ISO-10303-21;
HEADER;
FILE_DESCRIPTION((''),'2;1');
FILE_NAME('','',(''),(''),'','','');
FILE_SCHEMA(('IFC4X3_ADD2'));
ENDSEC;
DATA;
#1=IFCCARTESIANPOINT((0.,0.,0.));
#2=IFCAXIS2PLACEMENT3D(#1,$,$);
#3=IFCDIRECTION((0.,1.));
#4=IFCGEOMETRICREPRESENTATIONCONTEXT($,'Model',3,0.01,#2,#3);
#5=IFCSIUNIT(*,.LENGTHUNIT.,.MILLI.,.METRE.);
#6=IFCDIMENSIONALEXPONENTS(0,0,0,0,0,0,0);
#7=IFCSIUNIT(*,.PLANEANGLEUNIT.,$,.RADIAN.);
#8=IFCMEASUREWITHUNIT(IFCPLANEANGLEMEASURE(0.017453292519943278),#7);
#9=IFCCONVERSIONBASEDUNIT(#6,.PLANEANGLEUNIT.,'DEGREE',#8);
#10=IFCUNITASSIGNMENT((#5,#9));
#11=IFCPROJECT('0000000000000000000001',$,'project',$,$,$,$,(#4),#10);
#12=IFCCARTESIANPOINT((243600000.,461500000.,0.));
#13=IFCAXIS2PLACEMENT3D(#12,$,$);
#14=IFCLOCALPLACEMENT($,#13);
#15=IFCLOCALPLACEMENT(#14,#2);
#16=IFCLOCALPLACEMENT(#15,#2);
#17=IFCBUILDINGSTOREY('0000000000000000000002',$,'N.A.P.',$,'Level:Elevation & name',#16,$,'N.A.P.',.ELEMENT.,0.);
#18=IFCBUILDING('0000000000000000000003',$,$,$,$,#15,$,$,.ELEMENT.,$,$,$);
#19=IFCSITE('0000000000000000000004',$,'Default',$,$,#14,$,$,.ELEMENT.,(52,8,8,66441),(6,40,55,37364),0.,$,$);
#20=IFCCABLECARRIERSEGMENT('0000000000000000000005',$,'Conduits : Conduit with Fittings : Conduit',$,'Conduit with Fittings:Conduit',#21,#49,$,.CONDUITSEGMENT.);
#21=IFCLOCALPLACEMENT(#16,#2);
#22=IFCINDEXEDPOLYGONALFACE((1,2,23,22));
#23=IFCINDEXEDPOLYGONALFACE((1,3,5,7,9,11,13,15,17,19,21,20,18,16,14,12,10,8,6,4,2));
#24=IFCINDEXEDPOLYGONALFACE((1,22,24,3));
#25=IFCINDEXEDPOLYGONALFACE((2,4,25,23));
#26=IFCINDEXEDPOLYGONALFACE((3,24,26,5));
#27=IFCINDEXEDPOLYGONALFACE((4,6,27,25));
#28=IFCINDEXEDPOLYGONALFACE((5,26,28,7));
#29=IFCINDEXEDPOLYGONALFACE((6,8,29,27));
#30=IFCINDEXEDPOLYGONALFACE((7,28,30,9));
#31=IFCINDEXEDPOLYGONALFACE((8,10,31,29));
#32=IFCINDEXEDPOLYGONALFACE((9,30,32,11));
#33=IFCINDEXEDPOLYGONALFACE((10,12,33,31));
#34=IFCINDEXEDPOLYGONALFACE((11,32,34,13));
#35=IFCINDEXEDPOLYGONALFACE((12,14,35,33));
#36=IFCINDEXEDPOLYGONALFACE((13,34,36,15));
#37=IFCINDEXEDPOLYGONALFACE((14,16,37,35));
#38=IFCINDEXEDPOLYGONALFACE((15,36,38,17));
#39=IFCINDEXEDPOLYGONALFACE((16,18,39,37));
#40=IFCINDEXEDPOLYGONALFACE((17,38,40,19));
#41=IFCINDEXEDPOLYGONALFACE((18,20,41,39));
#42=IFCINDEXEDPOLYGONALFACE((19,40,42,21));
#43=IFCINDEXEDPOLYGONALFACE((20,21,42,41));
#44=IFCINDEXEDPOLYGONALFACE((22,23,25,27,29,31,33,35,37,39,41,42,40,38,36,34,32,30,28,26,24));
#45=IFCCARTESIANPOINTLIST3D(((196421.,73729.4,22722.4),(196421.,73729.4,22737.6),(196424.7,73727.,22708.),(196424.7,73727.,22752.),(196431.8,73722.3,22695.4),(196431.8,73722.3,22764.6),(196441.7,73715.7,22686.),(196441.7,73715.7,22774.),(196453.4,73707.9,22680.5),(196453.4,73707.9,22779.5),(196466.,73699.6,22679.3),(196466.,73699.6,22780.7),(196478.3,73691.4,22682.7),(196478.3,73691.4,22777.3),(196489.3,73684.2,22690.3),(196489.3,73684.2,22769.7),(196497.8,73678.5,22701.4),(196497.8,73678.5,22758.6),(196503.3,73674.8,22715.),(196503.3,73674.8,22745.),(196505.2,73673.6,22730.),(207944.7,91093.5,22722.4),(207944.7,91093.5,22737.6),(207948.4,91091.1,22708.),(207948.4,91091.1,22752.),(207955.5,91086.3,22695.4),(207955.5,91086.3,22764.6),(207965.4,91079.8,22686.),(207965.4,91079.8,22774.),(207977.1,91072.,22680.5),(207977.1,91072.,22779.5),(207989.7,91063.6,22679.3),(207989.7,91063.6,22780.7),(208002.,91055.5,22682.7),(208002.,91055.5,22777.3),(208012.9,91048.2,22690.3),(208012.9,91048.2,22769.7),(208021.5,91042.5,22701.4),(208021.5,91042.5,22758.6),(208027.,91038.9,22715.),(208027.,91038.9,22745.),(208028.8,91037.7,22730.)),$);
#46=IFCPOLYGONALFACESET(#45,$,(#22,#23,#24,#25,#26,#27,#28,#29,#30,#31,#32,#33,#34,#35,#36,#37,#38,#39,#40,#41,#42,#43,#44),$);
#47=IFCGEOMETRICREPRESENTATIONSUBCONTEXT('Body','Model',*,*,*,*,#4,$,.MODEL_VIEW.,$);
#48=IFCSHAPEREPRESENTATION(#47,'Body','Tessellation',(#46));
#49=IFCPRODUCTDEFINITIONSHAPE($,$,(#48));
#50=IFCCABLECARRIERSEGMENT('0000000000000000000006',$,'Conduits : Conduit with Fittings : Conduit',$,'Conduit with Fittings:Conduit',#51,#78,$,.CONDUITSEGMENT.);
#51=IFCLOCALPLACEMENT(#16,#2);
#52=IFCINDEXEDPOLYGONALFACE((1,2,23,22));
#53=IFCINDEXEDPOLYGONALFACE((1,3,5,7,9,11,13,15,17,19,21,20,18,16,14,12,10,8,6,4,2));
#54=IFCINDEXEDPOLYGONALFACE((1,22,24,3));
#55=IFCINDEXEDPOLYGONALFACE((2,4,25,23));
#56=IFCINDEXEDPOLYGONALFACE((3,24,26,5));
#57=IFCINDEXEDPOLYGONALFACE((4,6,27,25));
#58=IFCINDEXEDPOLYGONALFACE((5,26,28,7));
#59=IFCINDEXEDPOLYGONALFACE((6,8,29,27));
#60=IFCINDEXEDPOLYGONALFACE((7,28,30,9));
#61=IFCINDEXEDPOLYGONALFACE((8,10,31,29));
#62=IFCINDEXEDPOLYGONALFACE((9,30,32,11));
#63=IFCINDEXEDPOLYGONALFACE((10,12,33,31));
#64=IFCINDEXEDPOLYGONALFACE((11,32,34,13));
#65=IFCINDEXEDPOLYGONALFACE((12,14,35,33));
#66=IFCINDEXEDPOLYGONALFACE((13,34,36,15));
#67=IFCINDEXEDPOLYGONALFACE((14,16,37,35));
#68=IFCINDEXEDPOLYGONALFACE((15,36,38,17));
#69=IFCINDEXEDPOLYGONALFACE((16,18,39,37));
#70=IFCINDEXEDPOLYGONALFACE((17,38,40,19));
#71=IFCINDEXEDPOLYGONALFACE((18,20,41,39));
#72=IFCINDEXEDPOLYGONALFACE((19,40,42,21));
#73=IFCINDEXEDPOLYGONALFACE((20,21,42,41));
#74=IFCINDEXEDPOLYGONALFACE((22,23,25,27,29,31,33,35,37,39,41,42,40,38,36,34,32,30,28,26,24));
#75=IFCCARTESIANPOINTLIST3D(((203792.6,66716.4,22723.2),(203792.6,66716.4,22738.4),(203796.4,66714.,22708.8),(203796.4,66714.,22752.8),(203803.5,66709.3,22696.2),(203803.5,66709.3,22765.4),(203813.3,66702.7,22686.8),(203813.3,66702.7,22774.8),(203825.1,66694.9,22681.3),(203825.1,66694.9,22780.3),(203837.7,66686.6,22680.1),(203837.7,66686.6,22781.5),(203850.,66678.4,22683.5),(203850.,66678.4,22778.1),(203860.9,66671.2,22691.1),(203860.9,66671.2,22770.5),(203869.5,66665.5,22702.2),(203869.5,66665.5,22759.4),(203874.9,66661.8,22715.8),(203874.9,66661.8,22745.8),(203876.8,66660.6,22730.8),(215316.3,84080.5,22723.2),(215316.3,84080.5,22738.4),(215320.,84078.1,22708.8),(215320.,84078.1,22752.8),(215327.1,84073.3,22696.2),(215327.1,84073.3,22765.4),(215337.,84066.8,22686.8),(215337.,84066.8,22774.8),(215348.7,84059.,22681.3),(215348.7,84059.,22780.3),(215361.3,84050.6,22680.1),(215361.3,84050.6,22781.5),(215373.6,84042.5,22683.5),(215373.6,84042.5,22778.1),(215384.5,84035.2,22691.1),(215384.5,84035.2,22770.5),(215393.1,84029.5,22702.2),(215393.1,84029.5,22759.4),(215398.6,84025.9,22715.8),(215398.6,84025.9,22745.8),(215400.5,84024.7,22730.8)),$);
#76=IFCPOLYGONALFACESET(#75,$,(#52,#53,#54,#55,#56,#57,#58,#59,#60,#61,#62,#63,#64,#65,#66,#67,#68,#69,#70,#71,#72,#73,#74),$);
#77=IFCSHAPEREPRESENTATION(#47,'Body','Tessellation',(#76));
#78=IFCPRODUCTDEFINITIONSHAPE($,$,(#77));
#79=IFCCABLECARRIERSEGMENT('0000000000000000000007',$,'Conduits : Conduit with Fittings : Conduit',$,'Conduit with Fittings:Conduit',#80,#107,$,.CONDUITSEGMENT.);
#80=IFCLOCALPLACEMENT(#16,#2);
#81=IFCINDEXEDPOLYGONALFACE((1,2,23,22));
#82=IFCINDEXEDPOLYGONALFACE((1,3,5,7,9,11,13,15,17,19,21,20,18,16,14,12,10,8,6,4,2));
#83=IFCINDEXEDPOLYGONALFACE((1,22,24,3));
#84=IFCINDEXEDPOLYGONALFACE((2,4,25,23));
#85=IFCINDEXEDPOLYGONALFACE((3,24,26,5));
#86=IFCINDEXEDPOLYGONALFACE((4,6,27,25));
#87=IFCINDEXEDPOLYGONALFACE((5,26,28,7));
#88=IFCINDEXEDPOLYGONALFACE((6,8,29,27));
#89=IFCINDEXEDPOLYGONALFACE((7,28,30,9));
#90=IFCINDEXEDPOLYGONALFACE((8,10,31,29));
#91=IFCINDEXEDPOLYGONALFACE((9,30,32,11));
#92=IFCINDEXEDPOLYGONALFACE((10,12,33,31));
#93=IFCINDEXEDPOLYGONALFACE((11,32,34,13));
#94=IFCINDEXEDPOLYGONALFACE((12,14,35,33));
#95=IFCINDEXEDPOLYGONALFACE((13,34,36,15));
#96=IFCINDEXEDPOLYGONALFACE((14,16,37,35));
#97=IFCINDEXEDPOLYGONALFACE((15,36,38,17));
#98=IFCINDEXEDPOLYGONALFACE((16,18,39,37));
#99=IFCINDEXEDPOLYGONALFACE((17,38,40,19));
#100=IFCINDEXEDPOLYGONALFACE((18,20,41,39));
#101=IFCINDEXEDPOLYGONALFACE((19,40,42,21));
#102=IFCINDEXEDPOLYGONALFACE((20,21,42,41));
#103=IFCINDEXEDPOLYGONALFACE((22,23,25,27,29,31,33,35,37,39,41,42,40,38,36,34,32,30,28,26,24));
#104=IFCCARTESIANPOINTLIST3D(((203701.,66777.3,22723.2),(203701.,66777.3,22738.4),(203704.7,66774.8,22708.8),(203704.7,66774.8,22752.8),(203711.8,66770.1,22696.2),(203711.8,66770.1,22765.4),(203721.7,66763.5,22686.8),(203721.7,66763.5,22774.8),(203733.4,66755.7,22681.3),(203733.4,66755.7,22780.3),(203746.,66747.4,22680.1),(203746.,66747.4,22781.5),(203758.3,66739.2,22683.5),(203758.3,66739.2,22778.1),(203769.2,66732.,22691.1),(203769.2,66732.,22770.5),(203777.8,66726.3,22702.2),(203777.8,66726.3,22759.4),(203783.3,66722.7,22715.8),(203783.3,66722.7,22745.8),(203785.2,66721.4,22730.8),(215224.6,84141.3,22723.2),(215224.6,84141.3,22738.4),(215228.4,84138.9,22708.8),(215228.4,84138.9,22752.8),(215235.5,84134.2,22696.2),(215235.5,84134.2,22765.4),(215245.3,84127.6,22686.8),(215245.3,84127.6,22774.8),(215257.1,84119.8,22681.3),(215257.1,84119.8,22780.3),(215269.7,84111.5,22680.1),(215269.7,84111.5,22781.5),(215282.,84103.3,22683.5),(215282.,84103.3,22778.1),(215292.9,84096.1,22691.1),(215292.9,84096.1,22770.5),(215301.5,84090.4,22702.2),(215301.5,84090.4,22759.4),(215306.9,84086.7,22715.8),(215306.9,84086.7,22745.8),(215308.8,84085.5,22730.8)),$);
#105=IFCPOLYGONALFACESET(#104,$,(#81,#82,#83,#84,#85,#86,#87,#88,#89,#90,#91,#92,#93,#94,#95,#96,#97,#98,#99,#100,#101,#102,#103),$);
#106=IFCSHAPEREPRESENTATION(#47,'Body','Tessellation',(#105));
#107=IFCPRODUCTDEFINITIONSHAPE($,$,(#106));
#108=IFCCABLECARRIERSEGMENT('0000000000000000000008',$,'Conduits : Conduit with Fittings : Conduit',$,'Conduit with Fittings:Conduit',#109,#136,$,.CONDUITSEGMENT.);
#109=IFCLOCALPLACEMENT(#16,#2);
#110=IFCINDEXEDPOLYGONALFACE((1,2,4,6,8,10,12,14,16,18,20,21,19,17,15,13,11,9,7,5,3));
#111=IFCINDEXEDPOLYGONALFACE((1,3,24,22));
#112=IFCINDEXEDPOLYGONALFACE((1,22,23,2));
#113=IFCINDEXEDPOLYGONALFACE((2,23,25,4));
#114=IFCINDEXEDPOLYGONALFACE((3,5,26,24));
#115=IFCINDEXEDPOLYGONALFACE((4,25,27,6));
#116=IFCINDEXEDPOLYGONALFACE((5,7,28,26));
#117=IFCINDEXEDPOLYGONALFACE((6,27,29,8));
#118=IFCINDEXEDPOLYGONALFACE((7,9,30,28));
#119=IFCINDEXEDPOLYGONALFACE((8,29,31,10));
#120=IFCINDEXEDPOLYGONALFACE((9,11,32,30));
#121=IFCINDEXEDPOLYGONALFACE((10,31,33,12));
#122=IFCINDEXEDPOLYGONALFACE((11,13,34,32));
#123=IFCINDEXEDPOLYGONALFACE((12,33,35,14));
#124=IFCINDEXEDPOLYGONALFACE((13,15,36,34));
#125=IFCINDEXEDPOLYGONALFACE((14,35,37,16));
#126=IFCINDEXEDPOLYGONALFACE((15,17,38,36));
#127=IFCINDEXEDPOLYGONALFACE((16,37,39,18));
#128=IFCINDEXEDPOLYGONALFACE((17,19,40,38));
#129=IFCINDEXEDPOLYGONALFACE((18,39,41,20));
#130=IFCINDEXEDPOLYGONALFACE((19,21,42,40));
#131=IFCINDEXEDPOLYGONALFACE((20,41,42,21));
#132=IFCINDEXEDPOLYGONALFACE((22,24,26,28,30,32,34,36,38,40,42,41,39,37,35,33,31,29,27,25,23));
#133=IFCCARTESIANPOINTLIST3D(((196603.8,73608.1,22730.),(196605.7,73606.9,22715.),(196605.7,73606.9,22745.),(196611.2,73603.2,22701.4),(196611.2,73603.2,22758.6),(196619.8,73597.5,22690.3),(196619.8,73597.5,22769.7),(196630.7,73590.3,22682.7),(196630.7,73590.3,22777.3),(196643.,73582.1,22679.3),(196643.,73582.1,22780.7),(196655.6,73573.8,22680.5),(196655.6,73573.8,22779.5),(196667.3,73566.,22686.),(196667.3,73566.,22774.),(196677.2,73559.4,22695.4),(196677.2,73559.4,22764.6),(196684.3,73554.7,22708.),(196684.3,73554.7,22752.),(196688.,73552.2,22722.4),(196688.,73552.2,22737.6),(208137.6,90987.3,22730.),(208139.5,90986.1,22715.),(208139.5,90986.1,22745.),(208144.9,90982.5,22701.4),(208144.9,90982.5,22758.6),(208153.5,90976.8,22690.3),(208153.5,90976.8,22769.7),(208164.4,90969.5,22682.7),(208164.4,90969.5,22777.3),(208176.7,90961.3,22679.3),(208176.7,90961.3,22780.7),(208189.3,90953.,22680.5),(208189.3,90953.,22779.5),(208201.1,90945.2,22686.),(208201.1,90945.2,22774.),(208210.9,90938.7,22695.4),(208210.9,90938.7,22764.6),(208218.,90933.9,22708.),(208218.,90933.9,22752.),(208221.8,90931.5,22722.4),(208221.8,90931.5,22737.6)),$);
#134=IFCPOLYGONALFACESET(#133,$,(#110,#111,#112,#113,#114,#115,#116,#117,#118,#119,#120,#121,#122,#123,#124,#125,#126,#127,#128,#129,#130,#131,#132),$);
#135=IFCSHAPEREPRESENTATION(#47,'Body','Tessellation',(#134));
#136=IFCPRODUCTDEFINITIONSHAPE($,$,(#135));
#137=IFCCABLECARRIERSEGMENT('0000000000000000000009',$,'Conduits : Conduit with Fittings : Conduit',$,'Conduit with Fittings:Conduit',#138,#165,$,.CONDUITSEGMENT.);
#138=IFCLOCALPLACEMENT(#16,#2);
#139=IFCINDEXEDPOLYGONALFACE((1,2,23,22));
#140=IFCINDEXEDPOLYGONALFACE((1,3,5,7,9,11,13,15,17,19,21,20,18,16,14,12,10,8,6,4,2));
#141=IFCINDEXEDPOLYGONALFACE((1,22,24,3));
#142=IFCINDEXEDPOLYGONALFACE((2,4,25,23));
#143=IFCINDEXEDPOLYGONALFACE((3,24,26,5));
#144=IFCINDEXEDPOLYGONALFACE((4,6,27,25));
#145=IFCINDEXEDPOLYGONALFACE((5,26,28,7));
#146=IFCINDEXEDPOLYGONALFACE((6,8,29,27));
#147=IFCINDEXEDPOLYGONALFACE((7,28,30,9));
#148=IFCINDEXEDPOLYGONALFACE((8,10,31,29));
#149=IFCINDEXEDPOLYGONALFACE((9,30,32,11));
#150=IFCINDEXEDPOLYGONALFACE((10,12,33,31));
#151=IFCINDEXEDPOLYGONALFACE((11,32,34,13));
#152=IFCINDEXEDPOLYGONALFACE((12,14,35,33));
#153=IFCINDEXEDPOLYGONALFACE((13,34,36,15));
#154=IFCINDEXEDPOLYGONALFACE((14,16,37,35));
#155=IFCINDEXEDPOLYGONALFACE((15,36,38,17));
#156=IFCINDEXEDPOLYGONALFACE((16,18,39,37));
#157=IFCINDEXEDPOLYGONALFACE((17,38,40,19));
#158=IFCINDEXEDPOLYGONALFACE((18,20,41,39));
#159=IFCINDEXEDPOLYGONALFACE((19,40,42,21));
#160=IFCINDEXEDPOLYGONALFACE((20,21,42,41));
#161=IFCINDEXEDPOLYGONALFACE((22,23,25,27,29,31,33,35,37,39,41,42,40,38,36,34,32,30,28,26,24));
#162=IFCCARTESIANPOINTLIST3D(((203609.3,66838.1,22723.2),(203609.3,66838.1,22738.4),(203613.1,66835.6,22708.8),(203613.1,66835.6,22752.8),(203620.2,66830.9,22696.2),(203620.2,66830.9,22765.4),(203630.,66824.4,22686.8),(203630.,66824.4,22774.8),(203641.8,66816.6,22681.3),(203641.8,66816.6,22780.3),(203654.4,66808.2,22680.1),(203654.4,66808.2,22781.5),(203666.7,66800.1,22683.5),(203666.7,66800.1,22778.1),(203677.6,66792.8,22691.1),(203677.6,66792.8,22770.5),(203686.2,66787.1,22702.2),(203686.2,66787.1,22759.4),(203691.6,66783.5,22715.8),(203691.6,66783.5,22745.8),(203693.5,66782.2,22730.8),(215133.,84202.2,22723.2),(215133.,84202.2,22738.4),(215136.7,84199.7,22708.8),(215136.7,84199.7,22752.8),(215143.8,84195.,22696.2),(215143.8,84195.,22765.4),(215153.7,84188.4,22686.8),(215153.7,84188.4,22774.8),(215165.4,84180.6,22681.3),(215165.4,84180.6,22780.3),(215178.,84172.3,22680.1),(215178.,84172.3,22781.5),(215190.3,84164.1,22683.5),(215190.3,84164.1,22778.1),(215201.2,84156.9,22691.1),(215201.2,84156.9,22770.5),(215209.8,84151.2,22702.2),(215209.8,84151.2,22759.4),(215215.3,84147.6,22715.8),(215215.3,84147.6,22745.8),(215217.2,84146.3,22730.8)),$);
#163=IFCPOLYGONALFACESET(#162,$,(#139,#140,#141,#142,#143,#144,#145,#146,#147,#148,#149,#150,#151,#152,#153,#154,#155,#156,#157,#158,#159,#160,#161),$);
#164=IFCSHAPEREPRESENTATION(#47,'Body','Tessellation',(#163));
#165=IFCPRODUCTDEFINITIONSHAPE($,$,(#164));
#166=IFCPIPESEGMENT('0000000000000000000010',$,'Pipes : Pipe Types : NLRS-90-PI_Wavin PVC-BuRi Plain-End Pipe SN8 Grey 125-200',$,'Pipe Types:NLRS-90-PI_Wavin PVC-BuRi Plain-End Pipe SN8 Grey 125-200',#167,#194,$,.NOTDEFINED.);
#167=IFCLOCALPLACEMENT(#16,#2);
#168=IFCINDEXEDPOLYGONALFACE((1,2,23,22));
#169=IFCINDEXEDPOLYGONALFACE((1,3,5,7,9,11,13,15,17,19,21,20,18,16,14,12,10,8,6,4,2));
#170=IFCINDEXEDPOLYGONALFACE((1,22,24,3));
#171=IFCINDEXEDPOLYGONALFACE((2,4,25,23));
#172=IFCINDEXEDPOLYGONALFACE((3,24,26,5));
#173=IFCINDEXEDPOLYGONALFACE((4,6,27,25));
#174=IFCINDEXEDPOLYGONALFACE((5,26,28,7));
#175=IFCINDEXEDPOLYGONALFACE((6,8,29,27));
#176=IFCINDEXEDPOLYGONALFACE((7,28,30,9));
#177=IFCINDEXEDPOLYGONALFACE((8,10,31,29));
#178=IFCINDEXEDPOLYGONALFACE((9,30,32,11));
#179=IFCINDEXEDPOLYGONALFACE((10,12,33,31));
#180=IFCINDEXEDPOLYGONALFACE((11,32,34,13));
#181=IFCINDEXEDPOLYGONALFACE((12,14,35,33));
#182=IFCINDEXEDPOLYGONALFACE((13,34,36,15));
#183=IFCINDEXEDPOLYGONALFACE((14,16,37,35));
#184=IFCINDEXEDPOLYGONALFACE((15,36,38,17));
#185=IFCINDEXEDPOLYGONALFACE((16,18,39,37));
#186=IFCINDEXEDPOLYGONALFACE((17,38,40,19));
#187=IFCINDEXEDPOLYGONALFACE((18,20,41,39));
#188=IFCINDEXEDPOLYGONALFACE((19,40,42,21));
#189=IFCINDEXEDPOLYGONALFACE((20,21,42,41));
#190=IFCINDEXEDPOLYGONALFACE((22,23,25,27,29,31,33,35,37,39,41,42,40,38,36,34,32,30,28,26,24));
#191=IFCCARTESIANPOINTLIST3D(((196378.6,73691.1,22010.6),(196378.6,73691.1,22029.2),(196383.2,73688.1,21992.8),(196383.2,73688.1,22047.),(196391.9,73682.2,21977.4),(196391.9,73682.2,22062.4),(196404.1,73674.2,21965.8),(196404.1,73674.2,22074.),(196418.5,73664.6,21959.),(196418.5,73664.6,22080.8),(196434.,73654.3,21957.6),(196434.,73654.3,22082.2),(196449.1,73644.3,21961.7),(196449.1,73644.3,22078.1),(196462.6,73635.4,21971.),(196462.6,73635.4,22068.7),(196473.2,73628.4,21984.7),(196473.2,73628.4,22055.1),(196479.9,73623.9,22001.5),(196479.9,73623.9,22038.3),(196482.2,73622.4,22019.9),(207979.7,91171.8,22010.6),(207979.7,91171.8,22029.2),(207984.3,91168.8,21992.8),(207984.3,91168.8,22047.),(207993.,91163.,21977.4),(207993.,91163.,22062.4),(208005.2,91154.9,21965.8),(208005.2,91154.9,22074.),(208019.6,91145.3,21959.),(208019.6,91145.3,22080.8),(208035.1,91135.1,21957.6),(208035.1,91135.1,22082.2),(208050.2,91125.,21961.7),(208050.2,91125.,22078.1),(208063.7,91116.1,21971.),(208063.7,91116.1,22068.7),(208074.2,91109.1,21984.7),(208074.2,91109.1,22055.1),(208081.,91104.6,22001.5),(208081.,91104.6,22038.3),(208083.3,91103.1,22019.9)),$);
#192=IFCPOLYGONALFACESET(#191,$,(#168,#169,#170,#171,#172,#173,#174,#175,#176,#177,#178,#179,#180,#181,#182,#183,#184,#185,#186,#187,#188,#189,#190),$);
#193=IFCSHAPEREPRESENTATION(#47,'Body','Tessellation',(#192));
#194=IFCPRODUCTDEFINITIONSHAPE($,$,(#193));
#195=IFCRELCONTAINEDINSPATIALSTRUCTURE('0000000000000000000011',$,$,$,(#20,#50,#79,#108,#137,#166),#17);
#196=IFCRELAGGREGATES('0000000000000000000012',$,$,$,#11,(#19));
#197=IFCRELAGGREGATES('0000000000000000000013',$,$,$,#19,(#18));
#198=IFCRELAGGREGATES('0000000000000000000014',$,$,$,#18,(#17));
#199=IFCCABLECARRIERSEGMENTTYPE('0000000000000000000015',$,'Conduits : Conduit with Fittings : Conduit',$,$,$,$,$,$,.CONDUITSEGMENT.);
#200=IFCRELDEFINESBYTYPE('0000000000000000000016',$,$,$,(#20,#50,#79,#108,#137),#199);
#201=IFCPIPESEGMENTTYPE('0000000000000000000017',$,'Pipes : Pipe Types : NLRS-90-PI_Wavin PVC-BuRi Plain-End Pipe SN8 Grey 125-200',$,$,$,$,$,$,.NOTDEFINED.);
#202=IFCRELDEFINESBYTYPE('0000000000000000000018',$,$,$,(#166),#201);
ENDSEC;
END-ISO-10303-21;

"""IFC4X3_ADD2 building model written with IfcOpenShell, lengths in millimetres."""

from ifc_helpers import new_model, entity, si_unit, converted_unit, direction, frame, frame_2d, origin, origin_2d_with_axis, place, context, subcontext, project, spatial, circle, extrude, type_object, element, save


model = new_model("IFC4X3_ADD2")

# Units and contexts
model_context = context("Model", 3, precision=0.01, world=origin(), true_north=direction((0.0, 1.0)))
body_context = subcontext(model_context, "Body", "Model", "MODEL_VIEW")
ifc_project = project(units=[si_unit("LENGTHUNIT", "METRE", prefix="MILLI"), converted_unit("PLANEANGLEUNIT", "DEGREE", entity("IfcPlaneAngleMeasure", 0.017453292519943278), si_unit("PLANEANGLEUNIT", "RADIAN"), dimensions=[0, 0, 0, 0, 0, 0, 0])], contexts=[model_context])

# Site, building, storey
site_placement = place(None, frame((243600000.0, 461500000.0, 0.0)))
site = spatial("IfcSite", under=ifc_project, at=site_placement, Name="Default", CompositionType="ELEMENT", RefLatitude=(52, 8, 8, 66441), RefLongitude=(6, 40, 55, 37364), RefElevation=0.0)
building_placement = place(site_placement, origin())
building = spatial("IfcBuilding", under=site, at=building_placement, CompositionType="ELEMENT")
storey_placement = place(building_placement, origin())
storey = spatial("IfcBuildingStorey", under=building, at=storey_placement, Name="N.A.P.", ObjectType="Level:Elevation & name", LongName="N.A.P.", CompositionType="ELEMENT", Elevation=0.0)

# Cable carrier segments
cable_carrier_segment_type = type_object("IfcCableCarrierSegmentType", Name="Conduits : Conduit with Fittings : Conduit", PredefinedType="CONDUITSEGMENT")
cable_carrier_segment_1_placement = place(storey_placement, frame((196418.9, 73672.0, 22782.4)))
element("IfcCableCarrierSegment", 1, at=cable_carrier_segment_1_placement, inside=storey, type_object=cable_carrier_segment_type, Name="Conduits : Conduit with Fittings : Conduit", ObjectType="Conduit with Fittings:Conduit", PredefinedType="CONDUITSEGMENT", context=body_context, shape_type="SweptSolid", body=[
    extrude(circle(Radius=50.8, at=frame_2d((0.0, 0.0), x_axis=(1.0, 0.0))), frame((43.9, 29.7, -52.4), z_axis=(0.552959, 0.833209, 0.0), x_axis=(0.833209, -0.552959, 0.000005)), (0.0, 0.0, 1.0), 20840.0),
])
cable_carrier_segment_2_placement = place(storey_placement, frame((203790.6, 66659.0, 22678.4)))
element("IfcCableCarrierSegment", 2, at=cable_carrier_segment_2_placement, inside=storey, type_object=cable_carrier_segment_type, Name="Conduits : Conduit with Fittings : Conduit", ObjectType="Conduit with Fittings:Conduit", PredefinedType="CONDUITSEGMENT", context=body_context, shape_type="SweptSolid", body=[
    extrude(circle(Radius=50.8, at=origin_2d_with_axis()), frame((43.9, 29.7, 52.4), z_axis=(0.552959, 0.833209, 0.0), x_axis=(0.833209, -0.552959, 0.0)), (0.0, 0.0, 1.0), 20840.0),
])
cable_carrier_segment_3_placement = place(storey_placement, frame((203698.9, 66719.8, 22678.4)))
element("IfcCableCarrierSegment", 3, at=cable_carrier_segment_3_placement, inside=storey, type_object=cable_carrier_segment_type, Name="Conduits : Conduit with Fittings : Conduit", ObjectType="Conduit with Fittings:Conduit", PredefinedType="CONDUITSEGMENT", context=body_context, shape_type="SweptSolid", body=[
    extrude(circle(Radius=50.8, at=frame_2d((0.0, 0.0), x_axis=(1.0, 0.0))), frame((43.9, 29.7, 52.4), z_axis=(0.552959, 0.833209, 0.0), x_axis=(0.833209, -0.552959, 0.0)), (0.0, 0.0, 1.0), 20840.0),
])
cable_carrier_segment_4_placement = place(storey_placement, frame((196602.2, 73550.3, 22677.6)))
element("IfcCableCarrierSegment", 4, at=cable_carrier_segment_4_placement, inside=storey, type_object=cable_carrier_segment_type, Name="Conduits : Conduit with Fittings : Conduit", ObjectType="Conduit with Fittings:Conduit", PredefinedType="CONDUITSEGMENT", context=body_context, shape_type="SweptSolid", body=[
    extrude(circle(Radius=50.8, at=frame_2d((0.0, 0.0), x_axis=(1.0, 0.0))), frame((43.9, 29.7, 52.4), z_axis=(0.552959, 0.833208, 0.0), x_axis=(-0.833208, 0.552959, -0.000005)), (0.0, 0.0, 1.0), 20858.2),
])
cable_carrier_segment_5_placement = place(storey_placement, frame((203607.3, 66780.6, 22678.4)))
element("IfcCableCarrierSegment", 5, at=cable_carrier_segment_5_placement, inside=storey, type_object=cable_carrier_segment_type, Name="Conduits : Conduit with Fittings : Conduit", ObjectType="Conduit with Fittings:Conduit", PredefinedType="CONDUITSEGMENT", context=body_context, shape_type="SweptSolid", body=[
    extrude(circle(Radius=50.8, at=frame_2d((0.0, 0.0), x_axis=(1.0, 0.0))), frame((43.9, 29.7, 52.4), z_axis=(0.552959, 0.833209, 0.0), x_axis=(0.833209, -0.552959, 0.0)), (0.0, 0.0, 1.0), 20840.0),
])

# Pipe segment
pipe_segment_type = type_object("IfcPipeSegmentType", Name="Pipes : Pipe Types : NLRS-90-PI_Wavin PVC-BuRi Plain-End Pipe SN8 Grey 125-200", PredefinedType="NOTDEFINED")
pipe_segment_placement = place(storey_placement, frame((196376.5, 73620.8, 21955.8)))
element("IfcPipeSegment", 6, at=pipe_segment_placement, inside=storey, type_object=pipe_segment_type, Name="Pipes : Pipe Types : NLRS-90-PI_Wavin PVC-BuRi Plain-End Pipe SN8 Grey 125-200", ObjectType="Pipe Types:NLRS-90-PI_Wavin PVC-BuRi Plain-End Pipe SN8 Grey 125-200", PredefinedType="NOTDEFINED", context=body_context, shape_type="SweptSolid", body=[
    extrude(circle(Radius=62.5, at=origin_2d_with_axis()), frame((53.7, 36.2, 64.1), z_axis=(0.552959, 0.833209, 0.0), x_axis=(0.833209, -0.552959, 0.0)), (0.0, 0.0, 1.0), 20980.0),
])

save(model, "model.ifc")
